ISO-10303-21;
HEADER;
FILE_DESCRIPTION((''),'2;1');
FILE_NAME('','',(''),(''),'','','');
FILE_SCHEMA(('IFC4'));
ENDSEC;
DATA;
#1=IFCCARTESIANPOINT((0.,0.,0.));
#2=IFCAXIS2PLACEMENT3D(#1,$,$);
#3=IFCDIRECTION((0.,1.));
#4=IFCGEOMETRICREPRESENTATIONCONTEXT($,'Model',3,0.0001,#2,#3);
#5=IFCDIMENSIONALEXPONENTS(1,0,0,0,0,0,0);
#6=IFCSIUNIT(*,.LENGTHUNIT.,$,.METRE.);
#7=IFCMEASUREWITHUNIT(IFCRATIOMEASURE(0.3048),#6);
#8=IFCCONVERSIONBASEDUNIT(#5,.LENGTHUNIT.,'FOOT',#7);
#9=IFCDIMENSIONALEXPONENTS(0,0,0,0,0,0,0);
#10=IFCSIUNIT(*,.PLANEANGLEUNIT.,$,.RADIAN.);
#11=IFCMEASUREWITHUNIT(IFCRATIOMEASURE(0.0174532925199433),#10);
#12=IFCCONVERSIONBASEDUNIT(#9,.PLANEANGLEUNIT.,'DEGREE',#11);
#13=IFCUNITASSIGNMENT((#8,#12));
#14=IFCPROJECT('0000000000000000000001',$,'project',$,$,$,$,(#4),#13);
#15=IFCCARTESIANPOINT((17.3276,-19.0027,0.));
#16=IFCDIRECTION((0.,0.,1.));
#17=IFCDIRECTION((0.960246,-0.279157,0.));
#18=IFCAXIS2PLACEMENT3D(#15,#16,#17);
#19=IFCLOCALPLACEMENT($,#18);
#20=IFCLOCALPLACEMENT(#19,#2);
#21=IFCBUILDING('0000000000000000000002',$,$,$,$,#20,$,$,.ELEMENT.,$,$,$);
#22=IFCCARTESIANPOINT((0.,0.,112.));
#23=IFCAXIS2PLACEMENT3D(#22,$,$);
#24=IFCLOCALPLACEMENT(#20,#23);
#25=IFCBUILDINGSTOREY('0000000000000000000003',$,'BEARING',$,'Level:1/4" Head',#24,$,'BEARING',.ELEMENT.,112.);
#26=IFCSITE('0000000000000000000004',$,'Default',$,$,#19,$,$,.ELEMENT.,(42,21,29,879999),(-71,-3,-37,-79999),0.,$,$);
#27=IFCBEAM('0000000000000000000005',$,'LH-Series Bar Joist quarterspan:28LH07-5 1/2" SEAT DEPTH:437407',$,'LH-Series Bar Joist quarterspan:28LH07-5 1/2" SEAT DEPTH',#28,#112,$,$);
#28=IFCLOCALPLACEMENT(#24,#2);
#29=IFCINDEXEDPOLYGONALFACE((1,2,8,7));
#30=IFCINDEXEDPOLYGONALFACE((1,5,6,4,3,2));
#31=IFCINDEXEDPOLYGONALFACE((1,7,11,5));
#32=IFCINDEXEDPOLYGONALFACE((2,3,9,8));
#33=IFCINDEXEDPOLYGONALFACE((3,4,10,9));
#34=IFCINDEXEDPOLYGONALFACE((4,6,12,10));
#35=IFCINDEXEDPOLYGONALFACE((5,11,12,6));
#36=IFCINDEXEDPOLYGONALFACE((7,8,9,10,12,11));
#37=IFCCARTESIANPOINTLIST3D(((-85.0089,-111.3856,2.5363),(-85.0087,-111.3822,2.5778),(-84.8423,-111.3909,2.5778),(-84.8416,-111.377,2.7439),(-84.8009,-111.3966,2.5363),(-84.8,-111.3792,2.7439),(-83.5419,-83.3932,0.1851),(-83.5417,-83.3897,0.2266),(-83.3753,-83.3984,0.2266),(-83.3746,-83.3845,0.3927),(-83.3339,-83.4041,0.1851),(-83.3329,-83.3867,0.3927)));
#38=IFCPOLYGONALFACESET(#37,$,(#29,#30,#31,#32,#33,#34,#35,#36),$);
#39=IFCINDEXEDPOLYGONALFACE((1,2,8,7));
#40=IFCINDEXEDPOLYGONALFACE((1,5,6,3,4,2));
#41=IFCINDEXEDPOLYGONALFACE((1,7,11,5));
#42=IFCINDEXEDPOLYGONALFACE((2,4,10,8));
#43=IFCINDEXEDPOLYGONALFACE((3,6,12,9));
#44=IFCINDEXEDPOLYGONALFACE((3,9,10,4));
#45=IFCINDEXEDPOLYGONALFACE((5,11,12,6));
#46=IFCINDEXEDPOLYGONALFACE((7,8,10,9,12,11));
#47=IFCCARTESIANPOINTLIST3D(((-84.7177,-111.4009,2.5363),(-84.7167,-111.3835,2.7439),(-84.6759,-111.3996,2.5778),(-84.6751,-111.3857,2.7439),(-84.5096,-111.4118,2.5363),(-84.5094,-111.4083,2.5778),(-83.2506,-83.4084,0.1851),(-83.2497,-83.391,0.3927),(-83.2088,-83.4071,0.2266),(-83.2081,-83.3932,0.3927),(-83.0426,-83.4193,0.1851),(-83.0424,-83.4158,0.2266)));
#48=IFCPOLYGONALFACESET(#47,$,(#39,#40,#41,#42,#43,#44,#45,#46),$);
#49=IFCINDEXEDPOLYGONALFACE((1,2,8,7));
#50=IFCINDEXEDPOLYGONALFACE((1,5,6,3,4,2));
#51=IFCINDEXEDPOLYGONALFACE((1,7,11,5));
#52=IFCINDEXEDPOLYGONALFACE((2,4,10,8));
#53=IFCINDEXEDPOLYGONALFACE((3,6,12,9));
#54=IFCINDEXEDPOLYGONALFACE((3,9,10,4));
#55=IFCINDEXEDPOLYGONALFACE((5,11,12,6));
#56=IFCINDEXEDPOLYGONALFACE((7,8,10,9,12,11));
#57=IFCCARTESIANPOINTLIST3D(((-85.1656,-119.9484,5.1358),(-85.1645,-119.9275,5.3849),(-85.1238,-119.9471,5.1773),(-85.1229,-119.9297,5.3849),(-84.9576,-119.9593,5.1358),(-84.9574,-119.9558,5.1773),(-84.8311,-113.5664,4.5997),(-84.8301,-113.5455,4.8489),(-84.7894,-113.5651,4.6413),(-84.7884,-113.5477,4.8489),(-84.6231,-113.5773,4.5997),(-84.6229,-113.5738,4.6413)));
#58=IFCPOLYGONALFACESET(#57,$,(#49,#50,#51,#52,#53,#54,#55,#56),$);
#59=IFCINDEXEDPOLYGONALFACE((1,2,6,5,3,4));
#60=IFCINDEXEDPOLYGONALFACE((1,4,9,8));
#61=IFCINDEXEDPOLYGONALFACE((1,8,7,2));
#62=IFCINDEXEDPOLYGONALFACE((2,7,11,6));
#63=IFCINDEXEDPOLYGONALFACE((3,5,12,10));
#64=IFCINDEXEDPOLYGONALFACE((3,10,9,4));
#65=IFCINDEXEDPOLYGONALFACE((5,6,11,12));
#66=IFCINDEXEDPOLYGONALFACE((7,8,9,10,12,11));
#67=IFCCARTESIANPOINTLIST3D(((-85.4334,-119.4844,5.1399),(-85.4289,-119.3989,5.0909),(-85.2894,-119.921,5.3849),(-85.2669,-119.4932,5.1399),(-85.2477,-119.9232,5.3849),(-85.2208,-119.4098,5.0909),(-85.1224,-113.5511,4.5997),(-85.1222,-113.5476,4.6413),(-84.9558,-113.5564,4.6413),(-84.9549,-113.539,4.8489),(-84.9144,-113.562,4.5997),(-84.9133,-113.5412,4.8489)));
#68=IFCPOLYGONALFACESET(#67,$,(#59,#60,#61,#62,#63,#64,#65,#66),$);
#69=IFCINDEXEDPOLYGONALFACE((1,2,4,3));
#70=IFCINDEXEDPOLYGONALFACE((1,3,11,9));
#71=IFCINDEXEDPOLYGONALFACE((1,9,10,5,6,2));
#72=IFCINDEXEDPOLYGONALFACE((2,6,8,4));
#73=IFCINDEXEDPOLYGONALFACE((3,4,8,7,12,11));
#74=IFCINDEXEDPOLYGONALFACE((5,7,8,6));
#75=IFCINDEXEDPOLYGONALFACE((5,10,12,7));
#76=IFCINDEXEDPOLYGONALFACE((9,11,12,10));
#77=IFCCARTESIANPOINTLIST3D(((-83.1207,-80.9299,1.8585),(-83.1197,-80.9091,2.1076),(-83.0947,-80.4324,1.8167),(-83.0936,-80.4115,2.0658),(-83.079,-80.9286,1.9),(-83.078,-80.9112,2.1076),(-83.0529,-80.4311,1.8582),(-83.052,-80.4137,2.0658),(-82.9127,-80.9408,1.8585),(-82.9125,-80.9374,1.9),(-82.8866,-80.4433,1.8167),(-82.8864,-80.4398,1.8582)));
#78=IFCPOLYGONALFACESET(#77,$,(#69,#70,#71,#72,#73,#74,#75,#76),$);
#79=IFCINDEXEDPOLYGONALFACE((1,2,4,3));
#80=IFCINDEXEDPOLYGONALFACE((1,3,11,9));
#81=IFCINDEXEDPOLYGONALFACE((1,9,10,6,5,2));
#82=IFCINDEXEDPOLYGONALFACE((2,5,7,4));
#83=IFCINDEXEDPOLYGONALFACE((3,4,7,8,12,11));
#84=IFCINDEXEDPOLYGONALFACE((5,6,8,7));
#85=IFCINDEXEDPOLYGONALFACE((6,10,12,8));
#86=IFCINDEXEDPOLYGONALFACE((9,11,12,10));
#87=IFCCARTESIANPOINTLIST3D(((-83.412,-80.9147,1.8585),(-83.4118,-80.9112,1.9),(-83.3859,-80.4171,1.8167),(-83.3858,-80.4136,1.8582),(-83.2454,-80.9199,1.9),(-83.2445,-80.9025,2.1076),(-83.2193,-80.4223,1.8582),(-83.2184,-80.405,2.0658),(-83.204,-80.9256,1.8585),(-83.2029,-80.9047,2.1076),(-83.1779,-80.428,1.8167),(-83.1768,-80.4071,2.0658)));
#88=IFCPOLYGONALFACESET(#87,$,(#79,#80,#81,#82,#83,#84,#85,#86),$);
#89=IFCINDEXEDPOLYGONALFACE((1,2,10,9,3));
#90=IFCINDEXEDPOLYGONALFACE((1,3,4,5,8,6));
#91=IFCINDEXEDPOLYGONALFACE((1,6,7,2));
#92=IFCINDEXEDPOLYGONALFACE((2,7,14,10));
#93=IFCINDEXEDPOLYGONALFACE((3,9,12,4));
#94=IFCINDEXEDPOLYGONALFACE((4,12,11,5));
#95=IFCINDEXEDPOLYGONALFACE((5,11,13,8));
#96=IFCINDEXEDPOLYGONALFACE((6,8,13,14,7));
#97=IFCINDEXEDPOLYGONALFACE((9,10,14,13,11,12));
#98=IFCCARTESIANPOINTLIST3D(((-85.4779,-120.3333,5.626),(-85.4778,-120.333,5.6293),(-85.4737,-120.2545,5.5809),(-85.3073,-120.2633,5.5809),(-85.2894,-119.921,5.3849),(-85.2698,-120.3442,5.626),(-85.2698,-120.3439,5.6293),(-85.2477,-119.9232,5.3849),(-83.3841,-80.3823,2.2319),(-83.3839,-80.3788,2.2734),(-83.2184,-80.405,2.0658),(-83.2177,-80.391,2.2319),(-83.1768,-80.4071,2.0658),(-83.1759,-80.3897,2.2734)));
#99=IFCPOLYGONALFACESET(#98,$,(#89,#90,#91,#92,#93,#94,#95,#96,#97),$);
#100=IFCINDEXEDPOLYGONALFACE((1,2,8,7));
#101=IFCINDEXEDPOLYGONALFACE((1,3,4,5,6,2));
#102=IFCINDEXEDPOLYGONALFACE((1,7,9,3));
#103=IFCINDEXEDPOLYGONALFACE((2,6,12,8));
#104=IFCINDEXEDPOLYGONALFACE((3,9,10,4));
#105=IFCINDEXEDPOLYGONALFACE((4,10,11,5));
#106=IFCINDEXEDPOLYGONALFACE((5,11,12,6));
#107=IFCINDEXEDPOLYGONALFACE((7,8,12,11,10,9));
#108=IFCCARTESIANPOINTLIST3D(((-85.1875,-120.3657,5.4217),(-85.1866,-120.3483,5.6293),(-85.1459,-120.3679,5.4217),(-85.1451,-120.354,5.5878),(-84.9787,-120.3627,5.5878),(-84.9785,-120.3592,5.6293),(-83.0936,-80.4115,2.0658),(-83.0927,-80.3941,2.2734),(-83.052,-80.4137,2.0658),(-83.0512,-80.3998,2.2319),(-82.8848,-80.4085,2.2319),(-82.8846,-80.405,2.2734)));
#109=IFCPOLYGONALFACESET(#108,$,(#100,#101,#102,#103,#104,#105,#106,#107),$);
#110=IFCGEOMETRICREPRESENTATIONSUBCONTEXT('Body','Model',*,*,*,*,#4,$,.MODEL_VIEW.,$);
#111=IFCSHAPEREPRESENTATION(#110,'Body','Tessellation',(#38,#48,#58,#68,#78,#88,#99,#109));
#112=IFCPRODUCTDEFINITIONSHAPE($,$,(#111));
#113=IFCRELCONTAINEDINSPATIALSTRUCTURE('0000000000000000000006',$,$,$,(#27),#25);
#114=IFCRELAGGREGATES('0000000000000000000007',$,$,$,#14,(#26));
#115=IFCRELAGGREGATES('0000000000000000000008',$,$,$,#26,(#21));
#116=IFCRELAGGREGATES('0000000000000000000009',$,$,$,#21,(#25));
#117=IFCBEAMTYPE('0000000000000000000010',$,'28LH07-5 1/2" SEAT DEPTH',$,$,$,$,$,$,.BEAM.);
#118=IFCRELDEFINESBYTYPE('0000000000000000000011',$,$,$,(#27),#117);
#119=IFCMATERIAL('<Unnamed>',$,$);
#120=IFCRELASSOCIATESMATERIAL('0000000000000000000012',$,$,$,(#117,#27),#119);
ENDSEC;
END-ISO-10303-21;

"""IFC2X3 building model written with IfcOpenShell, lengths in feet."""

from ifc_helpers import new_model, entity, si_unit, converted_unit, direction, frame, origin, place, context, subcontext, project, spatial, polyline, outline, extrude, clip, halfspace, source, transform, mapped, material, type_object, type_shapes, element, save


model = new_model("IFC2X3")

# Units and contexts
model_context = context("Model", 3, precision=0.0001, world=origin(), true_north=direction((0.0, 1.0)))
body_context = subcontext(model_context, "Body", "Model", "MODEL_VIEW")
ifc_project = project(units=[converted_unit("LENGTHUNIT", "FOOT", entity("IfcRatioMeasure", 0.3048), si_unit("LENGTHUNIT", "METRE"), dimensions=[1, 0, 0, 0, 0, 0, 0]), converted_unit("PLANEANGLEUNIT", "DEGREE", entity("IfcRatioMeasure", 0.0174532925199433), si_unit("PLANEANGLEUNIT", "RADIAN"), dimensions=[0, 0, 0, 0, 0, 0, 0])], contexts=[model_context])

# Site, building, storey
site_placement = place(None, frame((17.3276, -19.0027, 0.0), z_axis=(0.0, 0.0, 1.0), x_axis=(0.960246, -0.279157, 0.0)))
site = spatial("IfcSite", under=ifc_project, at=site_placement, Name="Default", CompositionType="ELEMENT", RefLatitude=(42, 21, 29, 879999), RefLongitude=(-71, -3, -37, -79999), RefElevation=0.0)
building_placement = place(site_placement, origin())
building = spatial("IfcBuilding", under=site, at=building_placement, CompositionType="ELEMENT")
storey_placement = place(building_placement, frame((0.0, 0.0, 112.0)))
storey = spatial("IfcBuildingStorey", under=building, at=storey_placement, Name="BEARING", ObjectType="Level:1/4\" Head", LongName="BEARING", CompositionType="ELEMENT", Elevation=112.0)

# Beam
ifc_material_1 = material(Name="<Unnamed>")
beam_type_1 = type_object("IfcBeamType", Name="28LH07-5 1/2\" SEAT DEPTH", PredefinedType="BEAM", material=ifc_material_1)
shared_shape_1 = source(origin(), body_context, "Body", "SweptSolid", [
    extrude(outline(polyline([(-0.0833, -0.0833), (0.125, -0.0833), (0.125, -0.0417), (-0.0417, -0.0417), (-0.0417, 0.125), (-0.0833, 0.125), (-0.0833, -0.0833)])), frame((-83.4167, -83.3927, 112.2681), z_axis=(-0.052153, -0.995135, 0.083586), x_axis=(0.004375, 0.083471, 0.996501)), (0.0, 0.0, 1.0), 28.1293),
    extrude(outline(polyline([(-0.125, -0.0417), (-0.125, -0.0833), (0.0833, -0.0833), (0.0833, 0.125), (0.0417, 0.125), (0.0417, -0.0417), (-0.125, -0.0417)])), frame((-83.1671, -83.4058, 112.2681), z_axis=(0.052153, 0.995135, -0.083586), x_axis=(-0.99863, 0.052336, 0.0)), (0.0, 0.0, -1.0), 28.1293),
    extrude(outline(polyline([(-0.125, -0.0556), (-0.125, -0.0972), (0.0833, -0.0972), (0.0833, 0.1528), (0.0417, 0.1528), (0.0417, -0.0556), (-0.125, -0.0556)])), frame((-84.7475, -113.5626, 116.6966), z_axis=(0.052153, 0.995135, -0.083586), x_axis=(-0.99863, 0.052336, 0.0)), (0.0, 0.0, -1.0), 6.4132),
    clip(extrude(outline(polyline([(-0.0972, -0.0833), (0.1528, -0.0833), (0.1528, -0.0417), (-0.0556, -0.0417), (-0.0556, 0.125), (-0.0972, 0.125), (-0.0972, -0.0833)])), frame((-84.9972, -113.5495, 116.6966), z_axis=(-0.052153, -0.995135, 0.083586), x_axis=(0.004375, 0.083471, 0.996501)), (0.0, 0.0, 1.0), 6.4132), halfspace(frame((-125.3227, -118.2453, 117.6261), z_axis=(-0.025981, -0.495743, -0.868081), x_axis=(0.99863, -0.052336, 0.0)), False)),
    extrude(outline(polyline([(-0.0972, -0.125), (-0.0556, -0.125), (-0.0556, 0.0417), (0.1528, 0.0417), (0.1528, 0.0833), (-0.0972, 0.0833), (-0.0972, -0.125)])), frame((-83.011, -80.4286, 113.9135), z_axis=(-0.052153, -0.995135, 0.083586), x_axis=(0.004375, 0.083471, 0.996501)), (0.0, 0.0, 1.0), 0.5),
    extrude(outline(polyline([(-0.0972, -0.0833), (0.1528, -0.0833), (0.1528, -0.0417), (-0.0556, -0.0417), (-0.0556, 0.125), (-0.0972, 0.125), (-0.0972, -0.0833)])), frame((-83.2607, -80.4155, 113.9135), z_axis=(-0.052153, -0.995135, 0.083586), x_axis=(0.004375, 0.083471, 0.996501)), (0.0, 0.0, 1.0), 0.5),
    clip(extrude(outline(polyline([(-0.0833, -0.0833), (0.125, -0.0833), (0.125, -0.0417), (-0.0417, -0.0417), (-0.0417, 0.125), (-0.0833, 0.125), (-0.0833, -0.0833)])), frame((-83.2595, -80.3923, 114.1903), z_axis=(-0.052153, -0.995135, 0.083586), x_axis=(-0.99863, 0.052336, 0.0)), (0.0, 0.0, 1.0), 40.1495), halfspace(frame((-125.3227, -118.2453, 117.6261), z_axis=(-0.025981, -0.495743, -0.868081), x_axis=(0.99863, -0.052336, 0.0)), False)),
    extrude(outline(polyline([(-0.125, -0.0833), (0.0833, -0.0833), (0.0833, 0.125), (0.0417, 0.125), (0.0417, -0.0417), (-0.125, -0.0417), (-0.125, -0.0833)])), frame((-83.0098, -80.4054, 114.1903), z_axis=(-0.052153, -0.995135, 0.083586), x_axis=(-0.99863, 0.052336, 0.0)), (0.0, 0.0, 1.0), 40.1495),
])
type_shapes(beam_type_1, [shared_shape_1])
beam_1_placement = place(storey_placement, frame((0.0, 0.0, -112.0)))
element("IfcBeam", 1, at=beam_1_placement, inside=storey, type_object=beam_type_1, material=ifc_material_1, Name="LH-Series Bar Joist quarterspan:28LH07-5 1/2\" SEAT DEPTH:437407", ObjectType="LH-Series Bar Joist quarterspan:28LH07-5 1/2\" SEAT DEPTH", context=body_context, shape_type="MappedRepresentation", body=[
    mapped(shared_shape_1, transform((0.0, 0.0, 0.0), scale=1.0)),
])

save(model, "model.ifc")
